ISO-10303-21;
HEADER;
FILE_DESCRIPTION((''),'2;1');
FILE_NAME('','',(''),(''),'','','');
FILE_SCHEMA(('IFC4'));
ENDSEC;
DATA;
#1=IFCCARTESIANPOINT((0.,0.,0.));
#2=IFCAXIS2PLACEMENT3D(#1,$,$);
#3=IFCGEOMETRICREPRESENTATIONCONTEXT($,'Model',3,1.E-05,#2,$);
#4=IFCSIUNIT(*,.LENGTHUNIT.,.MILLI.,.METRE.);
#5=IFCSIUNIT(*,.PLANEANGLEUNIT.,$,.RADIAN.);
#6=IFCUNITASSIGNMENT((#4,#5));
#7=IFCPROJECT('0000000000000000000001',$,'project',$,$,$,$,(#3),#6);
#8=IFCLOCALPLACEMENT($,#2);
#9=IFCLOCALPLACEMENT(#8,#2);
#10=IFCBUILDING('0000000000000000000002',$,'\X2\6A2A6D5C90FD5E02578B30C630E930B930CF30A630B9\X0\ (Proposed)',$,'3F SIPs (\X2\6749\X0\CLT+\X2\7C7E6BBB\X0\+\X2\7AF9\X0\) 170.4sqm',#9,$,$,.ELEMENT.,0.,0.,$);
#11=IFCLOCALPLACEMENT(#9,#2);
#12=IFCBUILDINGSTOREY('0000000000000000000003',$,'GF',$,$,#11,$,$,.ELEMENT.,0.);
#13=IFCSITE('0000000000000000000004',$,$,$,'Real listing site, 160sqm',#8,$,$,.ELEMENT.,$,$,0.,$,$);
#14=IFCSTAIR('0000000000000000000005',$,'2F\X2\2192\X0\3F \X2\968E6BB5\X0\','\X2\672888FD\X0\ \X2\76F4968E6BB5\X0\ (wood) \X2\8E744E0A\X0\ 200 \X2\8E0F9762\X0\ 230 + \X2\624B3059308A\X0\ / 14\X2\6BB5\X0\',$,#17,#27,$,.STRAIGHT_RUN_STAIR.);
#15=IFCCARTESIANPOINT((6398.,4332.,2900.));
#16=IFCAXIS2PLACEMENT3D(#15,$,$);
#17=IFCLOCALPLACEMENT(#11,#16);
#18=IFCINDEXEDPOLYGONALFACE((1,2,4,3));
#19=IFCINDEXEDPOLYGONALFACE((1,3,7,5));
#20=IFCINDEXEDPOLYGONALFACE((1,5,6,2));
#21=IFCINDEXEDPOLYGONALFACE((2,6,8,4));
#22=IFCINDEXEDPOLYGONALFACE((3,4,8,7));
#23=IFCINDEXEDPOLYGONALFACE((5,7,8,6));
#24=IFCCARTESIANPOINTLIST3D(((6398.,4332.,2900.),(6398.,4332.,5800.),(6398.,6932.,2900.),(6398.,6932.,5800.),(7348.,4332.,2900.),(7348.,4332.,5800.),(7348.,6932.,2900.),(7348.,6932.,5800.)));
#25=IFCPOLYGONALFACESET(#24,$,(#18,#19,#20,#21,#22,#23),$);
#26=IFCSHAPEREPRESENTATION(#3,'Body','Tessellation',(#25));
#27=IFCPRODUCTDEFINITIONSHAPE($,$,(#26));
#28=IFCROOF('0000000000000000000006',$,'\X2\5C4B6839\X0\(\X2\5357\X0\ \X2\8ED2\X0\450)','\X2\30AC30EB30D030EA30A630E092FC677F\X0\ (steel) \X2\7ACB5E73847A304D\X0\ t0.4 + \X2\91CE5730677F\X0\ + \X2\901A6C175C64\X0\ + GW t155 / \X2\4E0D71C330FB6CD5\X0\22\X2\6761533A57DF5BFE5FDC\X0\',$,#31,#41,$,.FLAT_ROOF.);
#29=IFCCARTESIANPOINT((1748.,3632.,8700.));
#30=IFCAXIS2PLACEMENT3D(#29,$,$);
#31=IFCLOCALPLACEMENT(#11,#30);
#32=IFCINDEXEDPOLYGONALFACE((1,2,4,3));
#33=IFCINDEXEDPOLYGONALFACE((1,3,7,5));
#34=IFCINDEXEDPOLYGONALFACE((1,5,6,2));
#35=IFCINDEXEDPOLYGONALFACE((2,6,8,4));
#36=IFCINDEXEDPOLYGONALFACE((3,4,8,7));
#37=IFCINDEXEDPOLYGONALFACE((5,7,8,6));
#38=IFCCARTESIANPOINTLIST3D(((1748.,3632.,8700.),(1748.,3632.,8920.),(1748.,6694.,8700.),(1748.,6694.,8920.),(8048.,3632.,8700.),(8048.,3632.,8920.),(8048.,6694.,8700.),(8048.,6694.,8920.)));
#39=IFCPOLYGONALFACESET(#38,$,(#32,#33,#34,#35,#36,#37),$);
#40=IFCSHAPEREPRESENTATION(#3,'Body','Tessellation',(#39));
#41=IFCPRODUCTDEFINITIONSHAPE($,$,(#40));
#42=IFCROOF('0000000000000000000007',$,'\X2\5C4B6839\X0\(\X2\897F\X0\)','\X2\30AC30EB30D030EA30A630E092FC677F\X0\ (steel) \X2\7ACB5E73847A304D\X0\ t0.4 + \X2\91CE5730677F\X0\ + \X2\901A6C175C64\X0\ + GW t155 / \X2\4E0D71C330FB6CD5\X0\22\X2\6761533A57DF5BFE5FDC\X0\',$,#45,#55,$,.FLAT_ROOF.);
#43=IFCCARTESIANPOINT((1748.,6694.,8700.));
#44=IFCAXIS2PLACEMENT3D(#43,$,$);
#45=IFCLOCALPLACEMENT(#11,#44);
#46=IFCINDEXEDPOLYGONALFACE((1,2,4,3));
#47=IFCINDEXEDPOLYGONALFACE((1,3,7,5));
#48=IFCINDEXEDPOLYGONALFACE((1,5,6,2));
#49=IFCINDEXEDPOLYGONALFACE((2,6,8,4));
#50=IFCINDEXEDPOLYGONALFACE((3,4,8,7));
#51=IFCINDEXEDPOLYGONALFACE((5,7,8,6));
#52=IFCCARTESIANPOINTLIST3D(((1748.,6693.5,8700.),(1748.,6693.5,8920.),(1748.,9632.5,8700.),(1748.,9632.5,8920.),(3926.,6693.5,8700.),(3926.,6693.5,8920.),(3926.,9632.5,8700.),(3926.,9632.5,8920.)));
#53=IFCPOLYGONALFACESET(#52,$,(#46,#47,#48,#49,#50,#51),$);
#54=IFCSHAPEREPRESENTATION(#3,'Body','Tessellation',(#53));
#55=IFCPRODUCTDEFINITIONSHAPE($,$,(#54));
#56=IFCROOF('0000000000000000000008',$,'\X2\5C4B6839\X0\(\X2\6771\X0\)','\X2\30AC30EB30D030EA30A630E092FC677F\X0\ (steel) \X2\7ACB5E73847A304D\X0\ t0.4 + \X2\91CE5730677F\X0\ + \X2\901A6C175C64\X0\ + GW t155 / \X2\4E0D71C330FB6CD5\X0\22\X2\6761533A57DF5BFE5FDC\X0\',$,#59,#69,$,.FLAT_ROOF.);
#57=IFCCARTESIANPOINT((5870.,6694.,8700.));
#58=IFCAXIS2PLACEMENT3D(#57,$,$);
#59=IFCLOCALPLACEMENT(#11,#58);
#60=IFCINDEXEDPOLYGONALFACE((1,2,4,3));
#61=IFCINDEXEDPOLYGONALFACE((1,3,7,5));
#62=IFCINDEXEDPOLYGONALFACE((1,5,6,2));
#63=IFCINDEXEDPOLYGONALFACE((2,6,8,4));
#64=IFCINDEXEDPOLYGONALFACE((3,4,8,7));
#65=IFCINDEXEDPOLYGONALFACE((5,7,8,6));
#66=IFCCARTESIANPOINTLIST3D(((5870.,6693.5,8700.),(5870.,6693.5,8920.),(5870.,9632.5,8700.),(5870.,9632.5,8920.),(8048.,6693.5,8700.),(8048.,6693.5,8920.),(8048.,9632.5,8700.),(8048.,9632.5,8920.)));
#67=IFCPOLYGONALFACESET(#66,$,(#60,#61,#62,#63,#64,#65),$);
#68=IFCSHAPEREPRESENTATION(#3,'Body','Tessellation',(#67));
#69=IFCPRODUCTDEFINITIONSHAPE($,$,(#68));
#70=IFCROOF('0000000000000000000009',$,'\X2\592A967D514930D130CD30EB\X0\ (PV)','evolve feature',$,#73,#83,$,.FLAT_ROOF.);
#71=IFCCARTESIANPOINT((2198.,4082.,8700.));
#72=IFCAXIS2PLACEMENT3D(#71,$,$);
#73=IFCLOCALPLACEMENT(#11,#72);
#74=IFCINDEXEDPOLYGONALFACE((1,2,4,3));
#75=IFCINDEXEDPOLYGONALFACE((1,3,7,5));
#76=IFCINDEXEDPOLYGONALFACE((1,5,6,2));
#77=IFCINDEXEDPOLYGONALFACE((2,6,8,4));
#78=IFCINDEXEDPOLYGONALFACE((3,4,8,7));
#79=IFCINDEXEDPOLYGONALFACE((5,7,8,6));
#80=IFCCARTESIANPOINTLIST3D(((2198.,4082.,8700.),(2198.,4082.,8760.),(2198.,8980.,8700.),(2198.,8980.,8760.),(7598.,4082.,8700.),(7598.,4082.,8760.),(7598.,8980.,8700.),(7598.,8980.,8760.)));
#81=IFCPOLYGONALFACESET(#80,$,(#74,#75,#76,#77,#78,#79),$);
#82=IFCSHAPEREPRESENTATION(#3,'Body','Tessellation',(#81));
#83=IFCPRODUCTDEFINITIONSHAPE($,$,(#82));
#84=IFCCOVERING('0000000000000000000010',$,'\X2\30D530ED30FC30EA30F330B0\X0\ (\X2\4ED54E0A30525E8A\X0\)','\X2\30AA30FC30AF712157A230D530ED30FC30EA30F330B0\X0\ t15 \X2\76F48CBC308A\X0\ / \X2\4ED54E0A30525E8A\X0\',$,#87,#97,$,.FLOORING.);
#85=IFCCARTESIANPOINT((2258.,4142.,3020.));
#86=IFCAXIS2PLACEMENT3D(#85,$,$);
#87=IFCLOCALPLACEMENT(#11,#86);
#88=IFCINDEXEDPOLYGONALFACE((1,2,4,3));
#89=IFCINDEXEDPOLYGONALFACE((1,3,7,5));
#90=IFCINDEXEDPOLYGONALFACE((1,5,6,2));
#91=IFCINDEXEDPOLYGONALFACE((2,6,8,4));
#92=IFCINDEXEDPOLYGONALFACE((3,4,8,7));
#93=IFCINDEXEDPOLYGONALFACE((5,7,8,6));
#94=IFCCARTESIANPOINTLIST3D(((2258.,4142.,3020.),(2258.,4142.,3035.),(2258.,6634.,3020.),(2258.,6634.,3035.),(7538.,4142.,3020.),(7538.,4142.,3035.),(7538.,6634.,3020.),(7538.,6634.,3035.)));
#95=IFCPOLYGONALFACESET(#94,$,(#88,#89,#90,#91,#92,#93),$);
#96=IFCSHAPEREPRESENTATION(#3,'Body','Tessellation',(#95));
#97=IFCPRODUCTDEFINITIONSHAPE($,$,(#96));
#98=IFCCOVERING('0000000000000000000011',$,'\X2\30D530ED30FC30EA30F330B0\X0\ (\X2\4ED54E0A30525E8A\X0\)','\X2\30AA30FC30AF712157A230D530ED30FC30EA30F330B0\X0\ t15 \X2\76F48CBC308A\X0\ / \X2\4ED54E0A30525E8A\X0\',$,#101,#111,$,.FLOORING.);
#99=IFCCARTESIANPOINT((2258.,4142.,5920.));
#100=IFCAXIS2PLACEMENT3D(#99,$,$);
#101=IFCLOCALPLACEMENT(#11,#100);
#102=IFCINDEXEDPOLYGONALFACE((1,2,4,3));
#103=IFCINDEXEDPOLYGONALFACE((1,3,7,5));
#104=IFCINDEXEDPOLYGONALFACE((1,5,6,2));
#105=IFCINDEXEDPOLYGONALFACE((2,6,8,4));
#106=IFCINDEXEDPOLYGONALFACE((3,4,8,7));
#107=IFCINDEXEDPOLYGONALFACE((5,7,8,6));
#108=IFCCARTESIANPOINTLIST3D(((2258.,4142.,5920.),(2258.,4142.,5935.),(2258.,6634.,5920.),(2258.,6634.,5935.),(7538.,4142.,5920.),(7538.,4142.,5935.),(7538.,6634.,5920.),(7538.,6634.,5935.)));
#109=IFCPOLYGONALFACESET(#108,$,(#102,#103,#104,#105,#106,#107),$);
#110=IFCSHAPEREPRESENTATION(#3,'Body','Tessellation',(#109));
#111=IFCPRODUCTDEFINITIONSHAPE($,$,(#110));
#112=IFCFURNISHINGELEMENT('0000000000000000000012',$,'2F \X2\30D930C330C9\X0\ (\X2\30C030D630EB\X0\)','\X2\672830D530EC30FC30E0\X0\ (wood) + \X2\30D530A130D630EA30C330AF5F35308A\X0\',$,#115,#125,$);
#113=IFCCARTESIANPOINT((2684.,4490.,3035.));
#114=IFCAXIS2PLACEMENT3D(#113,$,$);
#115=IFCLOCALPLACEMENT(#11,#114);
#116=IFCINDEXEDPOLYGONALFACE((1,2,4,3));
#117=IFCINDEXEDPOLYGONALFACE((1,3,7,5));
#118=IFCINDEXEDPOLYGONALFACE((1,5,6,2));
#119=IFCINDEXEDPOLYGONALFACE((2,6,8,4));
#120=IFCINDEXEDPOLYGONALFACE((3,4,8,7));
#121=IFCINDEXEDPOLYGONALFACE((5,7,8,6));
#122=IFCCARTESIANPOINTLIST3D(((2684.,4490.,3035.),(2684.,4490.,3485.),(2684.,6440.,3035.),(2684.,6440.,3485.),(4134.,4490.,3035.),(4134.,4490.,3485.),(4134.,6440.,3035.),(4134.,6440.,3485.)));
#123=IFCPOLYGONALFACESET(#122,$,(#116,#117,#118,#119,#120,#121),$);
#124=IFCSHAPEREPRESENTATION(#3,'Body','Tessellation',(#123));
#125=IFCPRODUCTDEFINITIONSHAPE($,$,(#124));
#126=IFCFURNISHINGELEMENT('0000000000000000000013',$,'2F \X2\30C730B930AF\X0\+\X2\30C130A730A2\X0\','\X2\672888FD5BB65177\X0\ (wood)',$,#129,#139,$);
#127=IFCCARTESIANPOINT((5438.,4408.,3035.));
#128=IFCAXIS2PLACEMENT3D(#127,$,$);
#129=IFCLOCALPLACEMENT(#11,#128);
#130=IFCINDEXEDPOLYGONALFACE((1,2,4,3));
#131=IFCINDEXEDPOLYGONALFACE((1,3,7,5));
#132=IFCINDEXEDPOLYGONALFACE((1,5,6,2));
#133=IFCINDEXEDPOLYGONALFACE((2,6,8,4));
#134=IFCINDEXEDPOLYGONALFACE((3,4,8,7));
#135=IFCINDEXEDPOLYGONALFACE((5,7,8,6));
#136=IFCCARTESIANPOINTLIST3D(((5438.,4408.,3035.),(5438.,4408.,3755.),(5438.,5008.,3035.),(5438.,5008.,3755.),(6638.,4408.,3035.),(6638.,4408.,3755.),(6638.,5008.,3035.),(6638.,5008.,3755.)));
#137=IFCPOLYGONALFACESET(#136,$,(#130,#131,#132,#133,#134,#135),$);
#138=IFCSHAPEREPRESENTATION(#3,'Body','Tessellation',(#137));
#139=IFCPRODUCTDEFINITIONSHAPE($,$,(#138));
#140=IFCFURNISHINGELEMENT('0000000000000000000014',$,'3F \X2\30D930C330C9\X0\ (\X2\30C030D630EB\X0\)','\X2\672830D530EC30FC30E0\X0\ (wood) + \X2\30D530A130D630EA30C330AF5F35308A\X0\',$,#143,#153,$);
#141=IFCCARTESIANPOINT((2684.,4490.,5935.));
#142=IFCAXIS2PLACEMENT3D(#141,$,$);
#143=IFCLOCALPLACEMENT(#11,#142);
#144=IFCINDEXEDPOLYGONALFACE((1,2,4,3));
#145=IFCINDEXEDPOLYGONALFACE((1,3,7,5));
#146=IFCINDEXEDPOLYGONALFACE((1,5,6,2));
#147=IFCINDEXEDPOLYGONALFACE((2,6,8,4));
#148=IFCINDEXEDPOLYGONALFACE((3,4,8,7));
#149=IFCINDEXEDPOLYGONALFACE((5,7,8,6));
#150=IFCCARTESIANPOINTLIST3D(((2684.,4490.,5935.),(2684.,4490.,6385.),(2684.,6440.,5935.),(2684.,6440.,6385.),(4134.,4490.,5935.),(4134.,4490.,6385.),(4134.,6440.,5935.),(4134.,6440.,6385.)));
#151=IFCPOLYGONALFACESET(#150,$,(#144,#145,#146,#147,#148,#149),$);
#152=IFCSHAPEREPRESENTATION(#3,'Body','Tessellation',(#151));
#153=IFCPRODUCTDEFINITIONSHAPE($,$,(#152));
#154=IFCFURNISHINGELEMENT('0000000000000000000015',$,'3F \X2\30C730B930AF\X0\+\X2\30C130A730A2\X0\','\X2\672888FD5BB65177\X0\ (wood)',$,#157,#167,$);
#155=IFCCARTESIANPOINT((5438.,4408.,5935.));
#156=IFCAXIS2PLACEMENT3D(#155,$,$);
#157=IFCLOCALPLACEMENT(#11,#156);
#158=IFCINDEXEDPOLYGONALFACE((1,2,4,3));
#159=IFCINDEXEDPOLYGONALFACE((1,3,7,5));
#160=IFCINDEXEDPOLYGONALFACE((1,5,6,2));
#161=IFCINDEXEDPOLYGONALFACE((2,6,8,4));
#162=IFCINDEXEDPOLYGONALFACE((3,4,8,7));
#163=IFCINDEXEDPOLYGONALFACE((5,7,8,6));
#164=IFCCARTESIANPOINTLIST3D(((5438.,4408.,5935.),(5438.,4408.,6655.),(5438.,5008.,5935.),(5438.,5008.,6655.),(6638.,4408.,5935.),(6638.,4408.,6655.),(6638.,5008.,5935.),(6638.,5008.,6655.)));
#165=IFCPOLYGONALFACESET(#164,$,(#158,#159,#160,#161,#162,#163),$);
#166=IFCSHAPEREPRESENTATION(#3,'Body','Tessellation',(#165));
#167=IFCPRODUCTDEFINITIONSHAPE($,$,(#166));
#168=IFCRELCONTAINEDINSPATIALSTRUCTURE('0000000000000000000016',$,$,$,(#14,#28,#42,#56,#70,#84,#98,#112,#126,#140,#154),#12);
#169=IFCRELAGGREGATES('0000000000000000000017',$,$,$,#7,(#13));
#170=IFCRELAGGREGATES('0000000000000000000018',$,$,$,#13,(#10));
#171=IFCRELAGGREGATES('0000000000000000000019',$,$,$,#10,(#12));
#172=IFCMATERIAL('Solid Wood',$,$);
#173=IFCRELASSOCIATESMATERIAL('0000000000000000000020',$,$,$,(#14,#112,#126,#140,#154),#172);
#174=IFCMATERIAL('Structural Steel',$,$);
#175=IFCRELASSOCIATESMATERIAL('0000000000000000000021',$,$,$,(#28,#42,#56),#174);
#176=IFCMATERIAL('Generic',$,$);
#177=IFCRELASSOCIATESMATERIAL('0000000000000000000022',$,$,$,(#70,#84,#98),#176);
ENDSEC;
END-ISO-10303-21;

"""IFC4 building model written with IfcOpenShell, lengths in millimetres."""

from ifc_helpers import new_model, si_unit, frame, frame_2d, origin, place, context, project, spatial, rectangle, extrude, material, element, save


model = new_model("IFC4")

# Units and contexts
model_context = context("Model", 3, precision=1e-05, world=origin())
ifc_project = project(units=[si_unit("LENGTHUNIT", "METRE", prefix="MILLI"), si_unit("PLANEANGLEUNIT", "RADIAN")], contexts=[model_context])

# Site, building, storey
site_placement = place(None, origin())
site = spatial("IfcSite", under=ifc_project, at=site_placement, ObjectType="Real listing site, 160sqm", CompositionType="ELEMENT", RefElevation=0.0)
building_placement = place(site_placement, origin())
building = spatial("IfcBuilding", under=site, at=building_placement, Name="横浜都市型テラスハウス (Proposed)", ObjectType="3F SIPs (杉CLT+籾殻+竹) 170.4sqm", CompositionType="ELEMENT", ElevationOfRefHeight=0.0, ElevationOfTerrain=0.0)
storey_placement = place(building_placement, origin())
storey = spatial("IfcBuildingStorey", under=building, at=storey_placement, Name="GF", CompositionType="ELEMENT", Elevation=0.0)

# Shared definitions
ifc_material_1 = material(Name="Solid Wood")

# Stair
stair_placement = place(storey_placement, frame((6398.0, 4332.0, 2900.0)))
element("IfcStair", 1, at=stair_placement, inside=storey, material=ifc_material_1, Name="2F→3F 階段", Description="木製 直階段 (wood) 蹴上 200 踏面 230 + 手すり / 14段", PredefinedType="STRAIGHT_RUN_STAIR", context=model_context, shape_type="SweptSolid", body=[
    extrude(rectangle(XDim=950.0, YDim=2600.0, at=frame_2d((475.0, 1300.0))), frame((6398.0, 4332.0, 2900.0)), (0.0, 0.0, 1.0), 2900.0),
])

# Roofs
ifc_material_2 = material(Name="Structural Steel")
roof_1_placement = place(storey_placement, frame((1748.0, 3632.0, 8700.0)))
element("IfcRoof", 2, at=roof_1_placement, inside=storey, material=ifc_material_2, Name="屋根(南 軒450)", Description="ガルバリウム鋼板 (steel) 立平葺き t0.4 + 野地板 + 通気層 + GW t155 / 不燃・法22条区域対応", PredefinedType="FLAT_ROOF", context=model_context, shape_type="SweptSolid", body=[
    extrude(rectangle(XDim=6300.0, YDim=3062.0, at=frame_2d((3150.0, 1531.0))), frame((1748.0, 3632.0, 8700.0)), (0.0, 0.0, 1.0), 220.0),
])
roof_2_placement = place(storey_placement, frame((1748.0, 6694.0, 8700.0)))
element("IfcRoof", 3, at=roof_2_placement, inside=storey, material=ifc_material_2, Name="屋根(西)", Description="ガルバリウム鋼板 (steel) 立平葺き t0.4 + 野地板 + 通気層 + GW t155 / 不燃・法22条区域対応", PredefinedType="FLAT_ROOF", context=model_context, shape_type="SweptSolid", body=[
    extrude(rectangle(XDim=2178.0, YDim=2939.0, at=frame_2d((1089.0, 1469.0))), frame((1748.0, 6694.0, 8700.0)), (0.0, 0.0, 1.0), 220.0),
])
roof_3_placement = place(storey_placement, frame((5870.0, 6694.0, 8700.0)))
element("IfcRoof", 4, at=roof_3_placement, inside=storey, material=ifc_material_2, Name="屋根(東)", Description="ガルバリウム鋼板 (steel) 立平葺き t0.4 + 野地板 + 通気層 + GW t155 / 不燃・法22条区域対応", PredefinedType="FLAT_ROOF", context=model_context, shape_type="SweptSolid", body=[
    extrude(rectangle(XDim=2178.0, YDim=2939.0, at=frame_2d((1089.0, 1469.0))), frame((5870.0, 6694.0, 8700.0)), (0.0, 0.0, 1.0), 220.0),
])
ifc_material_3 = material(Name="Generic")
roof_4_placement = place(storey_placement, frame((2198.0, 4082.0, 8700.0)))
element("IfcRoof", 5, at=roof_4_placement, inside=storey, material=ifc_material_3, Name="太陽光パネル (PV)", Description="evolve feature", PredefinedType="FLAT_ROOF", context=model_context, shape_type="SweptSolid", body=[
    extrude(rectangle(XDim=5400.0, YDim=4898.0, at=frame_2d((2700.0, 2449.0))), frame((2198.0, 4082.0, 8700.0)), (0.0, 0.0, 1.0), 60.0),
])

# Coverings
covering_1_placement = place(storey_placement, frame((2258.0, 4142.0, 3020.0)))
element("IfcCovering", 6, at=covering_1_placement, inside=storey, material=ifc_material_3, Name="フローリング (仕上げ床)", Description="オーク無垢フローリング t15 直貼り / 仕上げ床", PredefinedType="FLOORING", context=model_context, shape_type="SweptSolid", body=[
    extrude(rectangle(XDim=5280.0, YDim=2492.0, at=frame_2d((2640.0, 1246.0))), frame((2258.0, 4142.0, 3020.0)), (0.0, 0.0, 1.0), 15.0),
])
covering_2_placement = place(storey_placement, frame((2258.0, 4142.0, 5920.0)))
element("IfcCovering", 7, at=covering_2_placement, inside=storey, material=ifc_material_3, Name="フローリング (仕上げ床)", Description="オーク無垢フローリング t15 直貼り / 仕上げ床", PredefinedType="FLOORING", context=model_context, shape_type="SweptSolid", body=[
    extrude(rectangle(XDim=5280.0, YDim=2492.0, at=frame_2d((2640.0, 1246.0))), frame((2258.0, 4142.0, 5920.0)), (0.0, 0.0, 1.0), 15.0),
])

# Furnishing elements
furnishing_1_placement = place(storey_placement, frame((2684.0, 4490.0, 3035.0)))
element("IfcFurnishingElement", 8, at=furnishing_1_placement, inside=storey, material=ifc_material_1, Name="2F ベッド (ダブル)", Description="木フレーム (wood) + ファブリック張り", context=model_context, shape_type="SweptSolid", body=[
    extrude(rectangle(XDim=1450.0, YDim=1950.0, at=frame_2d((725.0, 975.0))), frame((2684.0, 4490.0, 3035.0)), (0.0, 0.0, 1.0), 450.0),
])
furnishing_2_placement = place(storey_placement, frame((5438.0, 4408.0, 3035.0)))
element("IfcFurnishingElement", 9, at=furnishing_2_placement, inside=storey, material=ifc_material_1, Name="2F デスク+チェア", Description="木製家具 (wood)", context=model_context, shape_type="SweptSolid", body=[
    extrude(rectangle(XDim=1200.0, YDim=600.0, at=frame_2d((600.0, 300.0))), frame((5438.0, 4408.0, 3035.0)), (0.0, 0.0, 1.0), 720.0),
])
furnishing_3_placement = place(storey_placement, frame((2684.0, 4490.0, 5935.0)))
element("IfcFurnishingElement", 10, at=furnishing_3_placement, inside=storey, material=ifc_material_1, Name="3F ベッド (ダブル)", Description="木フレーム (wood) + ファブリック張り", context=model_context, shape_type="SweptSolid", body=[
    extrude(rectangle(XDim=1450.0, YDim=1950.0, at=frame_2d((725.0, 975.0))), frame((2684.0, 4490.0, 5935.0)), (0.0, 0.0, 1.0), 450.0),
])
furnishing_4_placement = place(storey_placement, frame((5438.0, 4408.0, 5935.0)))
element("IfcFurnishingElement", 11, at=furnishing_4_placement, inside=storey, material=ifc_material_1, Name="3F デスク+チェア", Description="木製家具 (wood)", context=model_context, shape_type="SweptSolid", body=[
    extrude(rectangle(XDim=1200.0, YDim=600.0, at=frame_2d((600.0, 300.0))), frame((5438.0, 4408.0, 5935.0)), (0.0, 0.0, 1.0), 720.0),
])

save(model, "model.ifc")
